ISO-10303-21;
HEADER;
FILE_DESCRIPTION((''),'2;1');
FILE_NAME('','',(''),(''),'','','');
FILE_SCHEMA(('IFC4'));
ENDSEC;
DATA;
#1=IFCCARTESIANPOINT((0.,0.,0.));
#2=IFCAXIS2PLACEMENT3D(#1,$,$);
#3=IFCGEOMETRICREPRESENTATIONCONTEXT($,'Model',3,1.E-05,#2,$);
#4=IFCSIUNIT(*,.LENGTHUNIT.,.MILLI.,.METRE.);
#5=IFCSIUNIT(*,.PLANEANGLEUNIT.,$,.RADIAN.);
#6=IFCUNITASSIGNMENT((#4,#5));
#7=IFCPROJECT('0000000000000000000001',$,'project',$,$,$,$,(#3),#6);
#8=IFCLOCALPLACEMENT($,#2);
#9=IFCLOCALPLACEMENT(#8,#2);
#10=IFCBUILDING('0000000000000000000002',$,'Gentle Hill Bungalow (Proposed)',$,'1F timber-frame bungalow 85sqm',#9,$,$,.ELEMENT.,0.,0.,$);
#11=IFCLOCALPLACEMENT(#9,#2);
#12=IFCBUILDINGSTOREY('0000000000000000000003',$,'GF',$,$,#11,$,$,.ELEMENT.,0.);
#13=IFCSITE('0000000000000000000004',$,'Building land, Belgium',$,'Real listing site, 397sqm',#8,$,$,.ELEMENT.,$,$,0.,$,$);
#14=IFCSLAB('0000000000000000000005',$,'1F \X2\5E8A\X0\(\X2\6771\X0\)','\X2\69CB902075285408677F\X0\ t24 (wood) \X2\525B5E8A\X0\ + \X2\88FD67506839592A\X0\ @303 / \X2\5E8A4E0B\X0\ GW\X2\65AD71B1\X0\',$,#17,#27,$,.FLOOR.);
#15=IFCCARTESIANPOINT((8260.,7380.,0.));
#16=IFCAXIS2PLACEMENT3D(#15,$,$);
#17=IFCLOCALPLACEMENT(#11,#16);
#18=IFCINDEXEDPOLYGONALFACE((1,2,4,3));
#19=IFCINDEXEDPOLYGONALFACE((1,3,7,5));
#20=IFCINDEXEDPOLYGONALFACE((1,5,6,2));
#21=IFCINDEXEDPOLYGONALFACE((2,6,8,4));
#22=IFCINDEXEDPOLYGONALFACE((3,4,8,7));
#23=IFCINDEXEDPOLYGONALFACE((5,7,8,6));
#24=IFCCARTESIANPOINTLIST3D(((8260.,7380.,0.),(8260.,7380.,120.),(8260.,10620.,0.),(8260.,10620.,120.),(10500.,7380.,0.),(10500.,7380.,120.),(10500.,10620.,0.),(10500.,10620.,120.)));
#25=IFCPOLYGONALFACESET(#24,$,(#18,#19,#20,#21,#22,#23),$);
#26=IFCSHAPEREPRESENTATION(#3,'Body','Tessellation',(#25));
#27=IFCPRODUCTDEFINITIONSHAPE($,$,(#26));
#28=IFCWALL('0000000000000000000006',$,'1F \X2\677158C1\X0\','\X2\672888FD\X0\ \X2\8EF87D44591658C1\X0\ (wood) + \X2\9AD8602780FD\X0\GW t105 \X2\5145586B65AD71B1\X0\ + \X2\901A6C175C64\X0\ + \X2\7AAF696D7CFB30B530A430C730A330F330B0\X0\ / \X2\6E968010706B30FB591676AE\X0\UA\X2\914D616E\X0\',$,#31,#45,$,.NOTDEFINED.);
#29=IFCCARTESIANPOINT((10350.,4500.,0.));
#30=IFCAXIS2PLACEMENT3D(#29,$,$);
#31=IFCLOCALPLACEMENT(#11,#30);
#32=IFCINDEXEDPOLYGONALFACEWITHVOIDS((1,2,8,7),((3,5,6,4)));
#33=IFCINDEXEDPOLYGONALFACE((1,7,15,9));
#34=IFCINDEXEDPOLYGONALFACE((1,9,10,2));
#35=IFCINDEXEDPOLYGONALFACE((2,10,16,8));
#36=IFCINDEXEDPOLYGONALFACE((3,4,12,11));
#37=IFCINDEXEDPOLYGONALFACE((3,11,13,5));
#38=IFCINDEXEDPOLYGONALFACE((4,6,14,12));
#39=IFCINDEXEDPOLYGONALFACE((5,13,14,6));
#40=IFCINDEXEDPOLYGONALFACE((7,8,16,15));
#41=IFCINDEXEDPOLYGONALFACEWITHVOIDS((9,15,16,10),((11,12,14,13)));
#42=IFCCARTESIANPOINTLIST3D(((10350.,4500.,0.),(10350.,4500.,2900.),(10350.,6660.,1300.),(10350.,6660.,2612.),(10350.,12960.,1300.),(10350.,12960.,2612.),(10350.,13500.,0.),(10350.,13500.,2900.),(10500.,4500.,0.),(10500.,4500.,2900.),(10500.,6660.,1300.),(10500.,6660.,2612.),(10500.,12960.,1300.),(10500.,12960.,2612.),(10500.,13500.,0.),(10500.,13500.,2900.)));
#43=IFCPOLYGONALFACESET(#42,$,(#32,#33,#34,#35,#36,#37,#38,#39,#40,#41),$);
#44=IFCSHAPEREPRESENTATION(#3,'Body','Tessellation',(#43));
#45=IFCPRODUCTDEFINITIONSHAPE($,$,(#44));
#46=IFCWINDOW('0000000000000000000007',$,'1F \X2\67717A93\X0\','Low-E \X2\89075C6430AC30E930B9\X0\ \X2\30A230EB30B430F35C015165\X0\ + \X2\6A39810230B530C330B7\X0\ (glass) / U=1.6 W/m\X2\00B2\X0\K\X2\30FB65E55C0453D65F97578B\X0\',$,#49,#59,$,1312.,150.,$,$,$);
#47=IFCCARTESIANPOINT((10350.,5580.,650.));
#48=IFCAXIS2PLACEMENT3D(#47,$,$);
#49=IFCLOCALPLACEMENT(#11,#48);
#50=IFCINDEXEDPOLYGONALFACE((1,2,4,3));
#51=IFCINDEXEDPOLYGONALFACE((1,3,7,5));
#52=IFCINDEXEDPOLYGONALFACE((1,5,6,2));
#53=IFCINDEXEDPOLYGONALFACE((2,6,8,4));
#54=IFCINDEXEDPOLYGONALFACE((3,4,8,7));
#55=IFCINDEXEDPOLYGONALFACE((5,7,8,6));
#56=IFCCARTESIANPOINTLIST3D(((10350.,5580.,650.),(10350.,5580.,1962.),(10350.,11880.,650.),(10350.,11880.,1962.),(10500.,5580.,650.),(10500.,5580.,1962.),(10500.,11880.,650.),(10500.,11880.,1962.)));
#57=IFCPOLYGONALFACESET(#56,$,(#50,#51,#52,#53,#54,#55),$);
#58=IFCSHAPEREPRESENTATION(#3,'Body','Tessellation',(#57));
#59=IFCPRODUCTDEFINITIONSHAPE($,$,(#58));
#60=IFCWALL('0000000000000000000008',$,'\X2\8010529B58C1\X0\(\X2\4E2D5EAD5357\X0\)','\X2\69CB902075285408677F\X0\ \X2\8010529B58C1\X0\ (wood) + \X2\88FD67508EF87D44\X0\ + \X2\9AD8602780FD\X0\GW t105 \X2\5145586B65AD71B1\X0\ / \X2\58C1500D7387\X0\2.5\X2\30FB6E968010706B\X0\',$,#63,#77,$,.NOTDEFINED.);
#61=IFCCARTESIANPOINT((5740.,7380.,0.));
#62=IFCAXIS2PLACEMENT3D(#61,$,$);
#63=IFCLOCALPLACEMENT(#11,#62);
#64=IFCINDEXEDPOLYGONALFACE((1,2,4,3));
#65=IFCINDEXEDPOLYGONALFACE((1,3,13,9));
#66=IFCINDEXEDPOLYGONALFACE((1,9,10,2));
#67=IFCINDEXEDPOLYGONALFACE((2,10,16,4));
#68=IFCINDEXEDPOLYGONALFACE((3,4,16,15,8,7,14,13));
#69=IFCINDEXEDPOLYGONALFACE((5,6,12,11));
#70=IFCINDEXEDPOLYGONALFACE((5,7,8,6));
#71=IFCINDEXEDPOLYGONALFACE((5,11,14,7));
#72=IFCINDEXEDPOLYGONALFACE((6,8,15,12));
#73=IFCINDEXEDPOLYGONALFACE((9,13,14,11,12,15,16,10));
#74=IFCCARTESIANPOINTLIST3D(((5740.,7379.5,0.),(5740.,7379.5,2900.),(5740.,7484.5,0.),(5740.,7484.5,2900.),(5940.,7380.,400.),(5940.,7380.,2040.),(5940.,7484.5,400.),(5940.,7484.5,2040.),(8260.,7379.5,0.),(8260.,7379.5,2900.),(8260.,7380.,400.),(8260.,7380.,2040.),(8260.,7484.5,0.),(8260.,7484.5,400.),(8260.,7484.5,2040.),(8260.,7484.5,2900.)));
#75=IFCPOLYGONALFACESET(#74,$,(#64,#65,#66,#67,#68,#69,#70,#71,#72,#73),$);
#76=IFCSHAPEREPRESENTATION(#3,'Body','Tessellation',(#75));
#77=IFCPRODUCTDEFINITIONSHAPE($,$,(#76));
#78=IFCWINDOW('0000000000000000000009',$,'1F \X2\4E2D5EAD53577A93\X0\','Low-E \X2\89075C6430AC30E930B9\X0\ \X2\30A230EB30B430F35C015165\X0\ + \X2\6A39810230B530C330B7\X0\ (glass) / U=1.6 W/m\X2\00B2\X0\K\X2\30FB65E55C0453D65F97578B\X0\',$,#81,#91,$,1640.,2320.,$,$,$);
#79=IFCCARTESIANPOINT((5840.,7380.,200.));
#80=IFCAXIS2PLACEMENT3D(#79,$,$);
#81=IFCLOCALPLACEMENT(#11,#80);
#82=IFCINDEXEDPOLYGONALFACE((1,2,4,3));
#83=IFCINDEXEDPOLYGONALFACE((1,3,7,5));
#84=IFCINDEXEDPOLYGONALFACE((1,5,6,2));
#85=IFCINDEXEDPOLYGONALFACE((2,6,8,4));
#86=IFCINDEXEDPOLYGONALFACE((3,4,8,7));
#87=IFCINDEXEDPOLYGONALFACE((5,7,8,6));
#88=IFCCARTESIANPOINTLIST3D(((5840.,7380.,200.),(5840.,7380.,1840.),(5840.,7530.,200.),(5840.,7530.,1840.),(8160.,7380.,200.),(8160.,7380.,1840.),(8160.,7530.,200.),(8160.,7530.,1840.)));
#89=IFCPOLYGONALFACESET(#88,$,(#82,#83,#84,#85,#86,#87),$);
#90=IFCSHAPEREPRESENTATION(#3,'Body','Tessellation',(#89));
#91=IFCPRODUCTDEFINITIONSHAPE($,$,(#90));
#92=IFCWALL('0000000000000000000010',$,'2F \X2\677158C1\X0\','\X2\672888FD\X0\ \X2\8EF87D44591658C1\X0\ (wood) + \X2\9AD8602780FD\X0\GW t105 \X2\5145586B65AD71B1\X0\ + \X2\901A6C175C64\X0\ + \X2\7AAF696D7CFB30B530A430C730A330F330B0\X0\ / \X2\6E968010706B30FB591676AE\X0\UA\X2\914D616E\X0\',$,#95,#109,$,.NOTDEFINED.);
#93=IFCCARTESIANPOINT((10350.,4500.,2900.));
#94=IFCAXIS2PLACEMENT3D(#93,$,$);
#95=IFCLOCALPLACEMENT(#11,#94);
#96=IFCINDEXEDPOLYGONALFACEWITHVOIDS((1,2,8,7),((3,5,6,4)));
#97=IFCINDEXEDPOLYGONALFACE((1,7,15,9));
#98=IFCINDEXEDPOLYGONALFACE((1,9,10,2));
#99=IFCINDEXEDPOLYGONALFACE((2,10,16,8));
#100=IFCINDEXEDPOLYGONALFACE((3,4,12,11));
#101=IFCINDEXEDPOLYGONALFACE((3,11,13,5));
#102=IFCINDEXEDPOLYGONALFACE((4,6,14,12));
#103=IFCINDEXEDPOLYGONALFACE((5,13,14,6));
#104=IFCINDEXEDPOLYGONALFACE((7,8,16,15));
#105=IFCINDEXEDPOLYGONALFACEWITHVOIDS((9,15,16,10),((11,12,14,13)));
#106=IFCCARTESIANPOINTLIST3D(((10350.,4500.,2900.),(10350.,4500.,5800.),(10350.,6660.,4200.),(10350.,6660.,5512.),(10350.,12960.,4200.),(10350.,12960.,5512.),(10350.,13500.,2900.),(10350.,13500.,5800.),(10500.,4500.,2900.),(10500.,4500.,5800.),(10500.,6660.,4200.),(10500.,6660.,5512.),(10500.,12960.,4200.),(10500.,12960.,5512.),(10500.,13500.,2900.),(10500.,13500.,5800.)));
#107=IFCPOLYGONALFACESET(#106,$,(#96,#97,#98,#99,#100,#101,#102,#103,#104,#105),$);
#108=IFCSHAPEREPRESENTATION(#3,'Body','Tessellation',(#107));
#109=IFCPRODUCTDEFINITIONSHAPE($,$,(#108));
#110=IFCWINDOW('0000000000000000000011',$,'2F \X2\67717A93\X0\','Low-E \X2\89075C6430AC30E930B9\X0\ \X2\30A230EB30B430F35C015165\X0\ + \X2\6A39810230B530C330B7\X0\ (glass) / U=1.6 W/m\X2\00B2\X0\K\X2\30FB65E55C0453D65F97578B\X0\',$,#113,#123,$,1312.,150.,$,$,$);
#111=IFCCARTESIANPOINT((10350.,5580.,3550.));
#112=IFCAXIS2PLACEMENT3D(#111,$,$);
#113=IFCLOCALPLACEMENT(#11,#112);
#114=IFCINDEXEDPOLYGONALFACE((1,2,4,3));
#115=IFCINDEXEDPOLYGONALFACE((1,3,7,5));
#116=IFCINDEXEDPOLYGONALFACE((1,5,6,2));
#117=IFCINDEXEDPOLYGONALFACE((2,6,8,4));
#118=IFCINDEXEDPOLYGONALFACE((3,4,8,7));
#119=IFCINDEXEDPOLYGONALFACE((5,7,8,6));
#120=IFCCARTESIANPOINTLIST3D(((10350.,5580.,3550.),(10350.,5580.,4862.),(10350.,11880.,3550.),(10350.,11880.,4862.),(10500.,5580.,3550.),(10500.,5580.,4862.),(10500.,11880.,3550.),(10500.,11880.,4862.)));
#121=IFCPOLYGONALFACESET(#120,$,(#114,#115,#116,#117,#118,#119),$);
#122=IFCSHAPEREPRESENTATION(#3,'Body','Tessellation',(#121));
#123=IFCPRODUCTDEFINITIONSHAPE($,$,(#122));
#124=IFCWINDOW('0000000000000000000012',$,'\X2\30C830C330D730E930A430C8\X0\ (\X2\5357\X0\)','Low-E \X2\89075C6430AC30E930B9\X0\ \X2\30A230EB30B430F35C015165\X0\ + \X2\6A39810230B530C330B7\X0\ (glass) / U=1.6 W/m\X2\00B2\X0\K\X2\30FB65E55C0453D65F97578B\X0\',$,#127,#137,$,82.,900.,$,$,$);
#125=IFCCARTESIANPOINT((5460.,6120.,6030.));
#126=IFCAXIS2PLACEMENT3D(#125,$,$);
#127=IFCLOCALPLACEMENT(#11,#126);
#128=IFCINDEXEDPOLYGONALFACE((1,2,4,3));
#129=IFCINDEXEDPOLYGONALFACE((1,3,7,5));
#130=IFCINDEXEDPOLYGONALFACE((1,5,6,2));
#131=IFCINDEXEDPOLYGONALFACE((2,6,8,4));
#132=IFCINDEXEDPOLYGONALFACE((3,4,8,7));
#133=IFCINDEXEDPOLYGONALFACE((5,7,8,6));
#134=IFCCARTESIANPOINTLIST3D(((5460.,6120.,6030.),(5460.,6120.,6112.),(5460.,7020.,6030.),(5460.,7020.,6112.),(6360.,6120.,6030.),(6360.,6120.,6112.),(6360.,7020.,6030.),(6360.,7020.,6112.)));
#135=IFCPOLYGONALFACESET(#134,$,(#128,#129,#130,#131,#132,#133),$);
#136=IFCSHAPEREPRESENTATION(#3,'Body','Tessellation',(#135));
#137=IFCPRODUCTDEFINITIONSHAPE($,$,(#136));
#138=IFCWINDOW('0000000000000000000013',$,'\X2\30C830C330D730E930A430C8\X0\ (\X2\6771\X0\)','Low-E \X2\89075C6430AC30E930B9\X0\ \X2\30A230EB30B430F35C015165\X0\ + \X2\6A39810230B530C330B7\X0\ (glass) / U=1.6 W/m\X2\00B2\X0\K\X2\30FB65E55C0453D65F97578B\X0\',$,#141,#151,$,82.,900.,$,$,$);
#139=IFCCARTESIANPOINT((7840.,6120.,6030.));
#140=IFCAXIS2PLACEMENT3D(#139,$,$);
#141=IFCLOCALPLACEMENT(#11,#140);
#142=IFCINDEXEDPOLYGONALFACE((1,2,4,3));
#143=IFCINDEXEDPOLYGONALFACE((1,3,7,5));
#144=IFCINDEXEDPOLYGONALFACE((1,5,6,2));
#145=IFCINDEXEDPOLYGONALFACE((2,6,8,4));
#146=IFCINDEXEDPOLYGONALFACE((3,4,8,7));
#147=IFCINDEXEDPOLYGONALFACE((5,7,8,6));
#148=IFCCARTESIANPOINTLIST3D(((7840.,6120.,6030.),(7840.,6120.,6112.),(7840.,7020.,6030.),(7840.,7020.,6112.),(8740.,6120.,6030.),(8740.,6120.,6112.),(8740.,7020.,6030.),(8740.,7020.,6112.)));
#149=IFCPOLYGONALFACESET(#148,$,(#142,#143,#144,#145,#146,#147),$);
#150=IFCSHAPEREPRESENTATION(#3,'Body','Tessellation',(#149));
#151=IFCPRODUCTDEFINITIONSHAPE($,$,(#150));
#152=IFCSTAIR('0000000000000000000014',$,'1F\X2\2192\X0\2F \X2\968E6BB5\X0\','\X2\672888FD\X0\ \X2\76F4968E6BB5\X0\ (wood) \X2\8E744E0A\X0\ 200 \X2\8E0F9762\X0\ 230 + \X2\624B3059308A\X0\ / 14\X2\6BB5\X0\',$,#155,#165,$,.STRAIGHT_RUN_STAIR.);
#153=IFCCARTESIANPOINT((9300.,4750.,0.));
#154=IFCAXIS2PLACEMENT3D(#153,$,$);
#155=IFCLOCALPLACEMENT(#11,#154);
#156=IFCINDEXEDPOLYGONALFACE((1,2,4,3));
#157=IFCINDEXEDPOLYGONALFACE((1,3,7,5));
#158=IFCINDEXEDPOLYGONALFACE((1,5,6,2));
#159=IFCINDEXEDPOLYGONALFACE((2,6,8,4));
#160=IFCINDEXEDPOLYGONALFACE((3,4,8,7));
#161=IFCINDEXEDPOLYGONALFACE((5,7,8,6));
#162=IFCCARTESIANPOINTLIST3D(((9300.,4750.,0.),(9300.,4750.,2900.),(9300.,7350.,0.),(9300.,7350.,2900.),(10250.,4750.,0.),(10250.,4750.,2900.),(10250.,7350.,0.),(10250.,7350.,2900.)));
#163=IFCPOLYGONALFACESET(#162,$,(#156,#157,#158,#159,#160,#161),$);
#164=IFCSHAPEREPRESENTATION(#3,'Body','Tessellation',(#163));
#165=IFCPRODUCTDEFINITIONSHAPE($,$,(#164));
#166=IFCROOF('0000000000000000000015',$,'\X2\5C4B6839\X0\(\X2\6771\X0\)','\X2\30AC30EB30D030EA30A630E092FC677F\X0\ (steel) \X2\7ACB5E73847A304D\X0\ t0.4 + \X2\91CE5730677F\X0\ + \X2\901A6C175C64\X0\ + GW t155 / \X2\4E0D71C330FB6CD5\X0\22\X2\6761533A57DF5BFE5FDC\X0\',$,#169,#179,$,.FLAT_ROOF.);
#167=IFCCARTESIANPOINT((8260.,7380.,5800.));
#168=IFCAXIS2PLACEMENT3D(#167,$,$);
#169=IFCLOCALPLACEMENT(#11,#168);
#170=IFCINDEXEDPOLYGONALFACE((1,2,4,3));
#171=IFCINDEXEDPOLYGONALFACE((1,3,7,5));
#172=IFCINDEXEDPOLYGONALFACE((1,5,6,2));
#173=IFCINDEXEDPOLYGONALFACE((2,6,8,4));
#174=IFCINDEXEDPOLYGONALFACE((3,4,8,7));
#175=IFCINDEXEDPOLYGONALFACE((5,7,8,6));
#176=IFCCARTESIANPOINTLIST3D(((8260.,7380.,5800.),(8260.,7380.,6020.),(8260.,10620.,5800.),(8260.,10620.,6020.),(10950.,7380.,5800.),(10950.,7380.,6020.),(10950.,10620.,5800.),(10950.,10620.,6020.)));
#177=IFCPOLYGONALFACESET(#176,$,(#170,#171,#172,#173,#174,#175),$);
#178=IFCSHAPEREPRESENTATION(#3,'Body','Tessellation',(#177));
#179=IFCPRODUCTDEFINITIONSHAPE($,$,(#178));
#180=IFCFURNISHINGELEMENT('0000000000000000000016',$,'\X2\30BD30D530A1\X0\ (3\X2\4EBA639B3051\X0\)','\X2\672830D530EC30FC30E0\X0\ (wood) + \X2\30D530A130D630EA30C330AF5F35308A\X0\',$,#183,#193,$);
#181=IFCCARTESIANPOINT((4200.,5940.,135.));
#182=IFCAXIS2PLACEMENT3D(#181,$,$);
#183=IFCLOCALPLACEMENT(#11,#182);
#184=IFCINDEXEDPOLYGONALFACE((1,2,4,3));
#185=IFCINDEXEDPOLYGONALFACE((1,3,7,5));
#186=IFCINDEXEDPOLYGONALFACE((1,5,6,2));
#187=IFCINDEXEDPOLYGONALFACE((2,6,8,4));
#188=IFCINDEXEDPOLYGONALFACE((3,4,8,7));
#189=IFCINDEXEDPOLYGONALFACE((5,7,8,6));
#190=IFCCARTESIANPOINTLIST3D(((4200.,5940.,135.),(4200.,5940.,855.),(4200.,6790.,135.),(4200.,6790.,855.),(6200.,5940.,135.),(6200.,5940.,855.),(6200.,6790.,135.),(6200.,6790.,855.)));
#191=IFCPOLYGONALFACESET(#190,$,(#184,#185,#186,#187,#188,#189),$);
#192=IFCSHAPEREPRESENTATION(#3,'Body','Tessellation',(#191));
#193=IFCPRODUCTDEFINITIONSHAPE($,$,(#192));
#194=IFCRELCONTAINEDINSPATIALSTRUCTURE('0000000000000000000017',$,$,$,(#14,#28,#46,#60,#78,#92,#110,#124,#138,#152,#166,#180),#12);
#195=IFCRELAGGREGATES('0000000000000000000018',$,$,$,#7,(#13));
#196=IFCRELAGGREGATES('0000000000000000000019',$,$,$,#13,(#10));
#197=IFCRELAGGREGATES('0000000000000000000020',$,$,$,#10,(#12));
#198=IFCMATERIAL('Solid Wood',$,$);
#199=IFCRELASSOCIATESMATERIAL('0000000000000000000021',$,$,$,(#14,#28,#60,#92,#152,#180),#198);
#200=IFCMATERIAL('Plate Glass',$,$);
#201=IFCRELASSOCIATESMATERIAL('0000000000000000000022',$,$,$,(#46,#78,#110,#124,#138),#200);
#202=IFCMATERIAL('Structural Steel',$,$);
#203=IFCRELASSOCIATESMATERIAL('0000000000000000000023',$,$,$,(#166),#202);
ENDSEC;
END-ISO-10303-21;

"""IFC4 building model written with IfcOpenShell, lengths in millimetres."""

from ifc_helpers import new_model, si_unit, frame, frame_2d, origin, place, context, project, spatial, rectangle, extrude, material, element, fill, save


model = new_model("IFC4")

# Units and contexts
model_context = context("Model", 3, precision=1e-05, world=origin())
ifc_project = project(units=[si_unit("LENGTHUNIT", "METRE", prefix="MILLI"), si_unit("PLANEANGLEUNIT", "RADIAN")], contexts=[model_context])

# Site, building, storey
site_placement = place(None, origin())
site = spatial("IfcSite", under=ifc_project, at=site_placement, Name="Building land, Belgium", ObjectType="Real listing site, 397sqm", CompositionType="ELEMENT", RefElevation=0.0)
building_placement = place(site_placement, origin())
building = spatial("IfcBuilding", under=site, at=building_placement, Name="Gentle Hill Bungalow (Proposed)", ObjectType="1F timber-frame bungalow 85sqm", CompositionType="ELEMENT", ElevationOfRefHeight=0.0, ElevationOfTerrain=0.0)
storey_placement = place(building_placement, origin())
storey = spatial("IfcBuildingStorey", under=building, at=storey_placement, Name="GF", CompositionType="ELEMENT", Elevation=0.0)

# Slab
ifc_material_1 = material(Name="Solid Wood")
slab_placement = place(storey_placement, frame((8260.0, 7380.0, 0.0)))
element("IfcSlab", 1, at=slab_placement, inside=storey, material=ifc_material_1, Name="1F 床(東)", Description="構造用合板 t24 (wood) 剛床 + 製材根太 @303 / 床下 GW断熱", PredefinedType="FLOOR", context=model_context, shape_type="SweptSolid", body=[
    extrude(rectangle(XDim=2240.0, YDim=3240.0, at=frame_2d((1120.0, 1620.0))), frame((8260.0, 7380.0, 0.0)), (0.0, 0.0, 1.0), 120.0),
])

# Walls, openings, windows
wall_1_placement = place(storey_placement, frame((10350.0, 4500.0, 0.0)))
wall_1 = element("IfcWall", 2, at=wall_1_placement, inside=storey, material=ifc_material_1, Name="1F 東壁", Description="木製 軸組外壁 (wood) + 高性能GW t105 充填断熱 + 通気層 + 窯業系サイディング / 準耐火・外皮UA配慮", PredefinedType="NOTDEFINED", context=model_context, shape_type="SweptSolid", body=[
    extrude(rectangle(XDim=150.0, YDim=9000.0, at=frame_2d((75.0, 4500.0))), frame((10350.0, 4500.0, 0.0)), (0.0, 0.0, 1.0), 2900.0),
])
opening_1_placement = place(storey_placement, frame((10350.0, 5580.0, 650.0)))
opening_1 = element("IfcOpeningElement", 3, at=opening_1_placement, cuts=wall_1, PredefinedType="NOTDEFINED", context=model_context, shape_type="SweptSolid", body=[
    extrude(rectangle(XDim=150.0, YDim=6300.0, at=frame_2d((75.0, 3150.0))), frame((10350.0, 5580.0, 650.0)), (0.0, 0.0, 1.0), 1312.0),
])
ifc_material_2 = material(Name="Plate Glass")
window_1_placement = place(storey_placement, frame((10350.0, 5580.0, 650.0)))
window_1 = element("IfcWindow", 4, at=window_1_placement, inside=storey, material=ifc_material_2, Name="1F 東窓", Description="Low-E 複層ガラス アルゴン封入 + 樹脂サッシ (glass) / U=1.6 W/m²K・日射取得型", OverallHeight=1312.0, OverallWidth=150.0, context=model_context, shape_type="SweptSolid", body=[
    extrude(rectangle(XDim=150.0, YDim=6300.0, at=frame_2d((75.0, 3150.0))), frame((10350.0, 5580.0, 650.0)), (0.0, 0.0, 1.0), 1312.0),
])
fill(opening_1, window_1)
wall_2_placement = place(storey_placement, frame((5740.0, 7380.0, 0.0)))
wall_2 = element("IfcWall", 5, at=wall_2_placement, inside=storey, material=ifc_material_1, Name="耐力壁(中庭南)", Description="構造用合板 耐力壁 (wood) + 製材軸組 + 高性能GW t105 充填断熱 / 壁倍率2.5・準耐火", PredefinedType="NOTDEFINED", context=model_context, shape_type="SweptSolid", body=[
    extrude(rectangle(XDim=2520.0, YDim=105.0, at=frame_2d((1260.0, 52.0))), frame((5740.0, 7380.0, 0.0)), (0.0, 0.0, 1.0), 2900.0),
])
opening_2_placement = place(storey_placement, frame((5840.0, 7380.0, 200.0)))
opening_2 = element("IfcOpeningElement", 6, at=opening_2_placement, cuts=wall_2, PredefinedType="NOTDEFINED", context=model_context, shape_type="SweptSolid", body=[
    extrude(rectangle(XDim=2320.0, YDim=150.0, at=frame_2d((1160.0, 75.0))), frame((5840.0, 7380.0, 200.0)), (0.0, 0.0, 1.0), 1640.0),
])
window_2_placement = place(storey_placement, frame((5840.0, 7380.0, 200.0)))
window_2 = element("IfcWindow", 7, at=window_2_placement, inside=storey, material=ifc_material_2, Name="1F 中庭南窓", Description="Low-E 複層ガラス アルゴン封入 + 樹脂サッシ (glass) / U=1.6 W/m²K・日射取得型", OverallHeight=1640.0, OverallWidth=2320.0, context=model_context, shape_type="SweptSolid", body=[
    extrude(rectangle(XDim=2320.0, YDim=150.0, at=frame_2d((1160.0, 75.0))), frame((5840.0, 7380.0, 200.0)), (0.0, 0.0, 1.0), 1640.0),
])
fill(opening_2, window_2)

# Wall, opening, window
wall_3_placement = place(storey_placement, frame((10350.0, 4500.0, 2900.0)))
wall_3 = element("IfcWall", 8, at=wall_3_placement, inside=storey, material=ifc_material_1, Name="2F 東壁", Description="木製 軸組外壁 (wood) + 高性能GW t105 充填断熱 + 通気層 + 窯業系サイディング / 準耐火・外皮UA配慮", PredefinedType="NOTDEFINED", context=model_context, shape_type="SweptSolid", body=[
    extrude(rectangle(XDim=150.0, YDim=9000.0, at=frame_2d((75.0, 4500.0))), frame((10350.0, 4500.0, 2900.0)), (0.0, 0.0, 1.0), 2900.0),
])
opening_3_placement = place(storey_placement, frame((10350.0, 5580.0, 3550.0)))
opening_3 = element("IfcOpeningElement", 9, at=opening_3_placement, cuts=wall_3, PredefinedType="NOTDEFINED", context=model_context, shape_type="SweptSolid", body=[
    extrude(rectangle(XDim=150.0, YDim=6300.0, at=frame_2d((75.0, 3150.0))), frame((10350.0, 5580.0, 3550.0)), (0.0, 0.0, 1.0), 1312.0),
])
window_3_placement = place(storey_placement, frame((10350.0, 5580.0, 3550.0)))
window_3 = element("IfcWindow", 10, at=window_3_placement, inside=storey, material=ifc_material_2, Name="2F 東窓", Description="Low-E 複層ガラス アルゴン封入 + 樹脂サッシ (glass) / U=1.6 W/m²K・日射取得型", OverallHeight=1312.0, OverallWidth=150.0, context=model_context, shape_type="SweptSolid", body=[
    extrude(rectangle(XDim=150.0, YDim=6300.0, at=frame_2d((75.0, 3150.0))), frame((10350.0, 5580.0, 3550.0)), (0.0, 0.0, 1.0), 1312.0),
])
fill(opening_3, window_3)

# Windows
window_4_placement = place(storey_placement, frame((5460.0, 6120.0, 6030.0)))
element("IfcWindow", 11, at=window_4_placement, inside=storey, material=ifc_material_2, Name="トップライト (南)", Description="Low-E 複層ガラス アルゴン封入 + 樹脂サッシ (glass) / U=1.6 W/m²K・日射取得型", OverallHeight=82.0, OverallWidth=900.0, context=model_context, shape_type="SweptSolid", body=[
    extrude(rectangle(XDim=900.0, YDim=900.0, at=frame_2d((450.0, 450.0))), frame((5460.0, 6120.0, 6030.0)), (0.0, 0.0, 1.0), 82.0),
])
window_5_placement = place(storey_placement, frame((7840.0, 6120.0, 6030.0)))
element("IfcWindow", 12, at=window_5_placement, inside=storey, material=ifc_material_2, Name="トップライト (東)", Description="Low-E 複層ガラス アルゴン封入 + 樹脂サッシ (glass) / U=1.6 W/m²K・日射取得型", OverallHeight=82.0, OverallWidth=900.0, context=model_context, shape_type="SweptSolid", body=[
    extrude(rectangle(XDim=900.0, YDim=900.0, at=frame_2d((450.0, 450.0))), frame((7840.0, 6120.0, 6030.0)), (0.0, 0.0, 1.0), 82.0),
])

# Stair
stair_placement = place(storey_placement, frame((9300.0, 4750.0, 0.0)))
element("IfcStair", 13, at=stair_placement, inside=storey, material=ifc_material_1, Name="1F→2F 階段", Description="木製 直階段 (wood) 蹴上 200 踏面 230 + 手すり / 14段", PredefinedType="STRAIGHT_RUN_STAIR", context=model_context, shape_type="SweptSolid", body=[
    extrude(rectangle(XDim=950.0, YDim=2600.0, at=frame_2d((475.0, 1300.0))), frame((9300.0, 4750.0, 0.0)), (0.0, 0.0, 1.0), 2900.0),
])

# Roof
ifc_material_3 = material(Name="Structural Steel")
roof_placement = place(storey_placement, frame((8260.0, 7380.0, 5800.0)))
element("IfcRoof", 14, at=roof_placement, inside=storey, material=ifc_material_3, Name="屋根(東)", Description="ガルバリウム鋼板 (steel) 立平葺き t0.4 + 野地板 + 通気層 + GW t155 / 不燃・法22条区域対応", PredefinedType="FLAT_ROOF", context=model_context, shape_type="SweptSolid", body=[
    extrude(rectangle(XDim=2690.0, YDim=3240.0, at=frame_2d((1345.0, 1620.0))), frame((8260.0, 7380.0, 5800.0)), (0.0, 0.0, 1.0), 220.0),
])

# Furnishing element
furnishing_1_placement = place(storey_placement, frame((4200.0, 5940.0, 135.0)))
element("IfcFurnishingElement", 15, at=furnishing_1_placement, inside=storey, material=ifc_material_1, Name="ソファ (3人掛け)", Description="木フレーム (wood) + ファブリック張り", context=model_context, shape_type="SweptSolid", body=[
    extrude(rectangle(XDim=2000.0, YDim=850.0, at=frame_2d((1000.0, 425.0))), frame((4200.0, 5940.0, 135.0)), (0.0, 0.0, 1.0), 720.0),
])

save(model, "model.ifc")
